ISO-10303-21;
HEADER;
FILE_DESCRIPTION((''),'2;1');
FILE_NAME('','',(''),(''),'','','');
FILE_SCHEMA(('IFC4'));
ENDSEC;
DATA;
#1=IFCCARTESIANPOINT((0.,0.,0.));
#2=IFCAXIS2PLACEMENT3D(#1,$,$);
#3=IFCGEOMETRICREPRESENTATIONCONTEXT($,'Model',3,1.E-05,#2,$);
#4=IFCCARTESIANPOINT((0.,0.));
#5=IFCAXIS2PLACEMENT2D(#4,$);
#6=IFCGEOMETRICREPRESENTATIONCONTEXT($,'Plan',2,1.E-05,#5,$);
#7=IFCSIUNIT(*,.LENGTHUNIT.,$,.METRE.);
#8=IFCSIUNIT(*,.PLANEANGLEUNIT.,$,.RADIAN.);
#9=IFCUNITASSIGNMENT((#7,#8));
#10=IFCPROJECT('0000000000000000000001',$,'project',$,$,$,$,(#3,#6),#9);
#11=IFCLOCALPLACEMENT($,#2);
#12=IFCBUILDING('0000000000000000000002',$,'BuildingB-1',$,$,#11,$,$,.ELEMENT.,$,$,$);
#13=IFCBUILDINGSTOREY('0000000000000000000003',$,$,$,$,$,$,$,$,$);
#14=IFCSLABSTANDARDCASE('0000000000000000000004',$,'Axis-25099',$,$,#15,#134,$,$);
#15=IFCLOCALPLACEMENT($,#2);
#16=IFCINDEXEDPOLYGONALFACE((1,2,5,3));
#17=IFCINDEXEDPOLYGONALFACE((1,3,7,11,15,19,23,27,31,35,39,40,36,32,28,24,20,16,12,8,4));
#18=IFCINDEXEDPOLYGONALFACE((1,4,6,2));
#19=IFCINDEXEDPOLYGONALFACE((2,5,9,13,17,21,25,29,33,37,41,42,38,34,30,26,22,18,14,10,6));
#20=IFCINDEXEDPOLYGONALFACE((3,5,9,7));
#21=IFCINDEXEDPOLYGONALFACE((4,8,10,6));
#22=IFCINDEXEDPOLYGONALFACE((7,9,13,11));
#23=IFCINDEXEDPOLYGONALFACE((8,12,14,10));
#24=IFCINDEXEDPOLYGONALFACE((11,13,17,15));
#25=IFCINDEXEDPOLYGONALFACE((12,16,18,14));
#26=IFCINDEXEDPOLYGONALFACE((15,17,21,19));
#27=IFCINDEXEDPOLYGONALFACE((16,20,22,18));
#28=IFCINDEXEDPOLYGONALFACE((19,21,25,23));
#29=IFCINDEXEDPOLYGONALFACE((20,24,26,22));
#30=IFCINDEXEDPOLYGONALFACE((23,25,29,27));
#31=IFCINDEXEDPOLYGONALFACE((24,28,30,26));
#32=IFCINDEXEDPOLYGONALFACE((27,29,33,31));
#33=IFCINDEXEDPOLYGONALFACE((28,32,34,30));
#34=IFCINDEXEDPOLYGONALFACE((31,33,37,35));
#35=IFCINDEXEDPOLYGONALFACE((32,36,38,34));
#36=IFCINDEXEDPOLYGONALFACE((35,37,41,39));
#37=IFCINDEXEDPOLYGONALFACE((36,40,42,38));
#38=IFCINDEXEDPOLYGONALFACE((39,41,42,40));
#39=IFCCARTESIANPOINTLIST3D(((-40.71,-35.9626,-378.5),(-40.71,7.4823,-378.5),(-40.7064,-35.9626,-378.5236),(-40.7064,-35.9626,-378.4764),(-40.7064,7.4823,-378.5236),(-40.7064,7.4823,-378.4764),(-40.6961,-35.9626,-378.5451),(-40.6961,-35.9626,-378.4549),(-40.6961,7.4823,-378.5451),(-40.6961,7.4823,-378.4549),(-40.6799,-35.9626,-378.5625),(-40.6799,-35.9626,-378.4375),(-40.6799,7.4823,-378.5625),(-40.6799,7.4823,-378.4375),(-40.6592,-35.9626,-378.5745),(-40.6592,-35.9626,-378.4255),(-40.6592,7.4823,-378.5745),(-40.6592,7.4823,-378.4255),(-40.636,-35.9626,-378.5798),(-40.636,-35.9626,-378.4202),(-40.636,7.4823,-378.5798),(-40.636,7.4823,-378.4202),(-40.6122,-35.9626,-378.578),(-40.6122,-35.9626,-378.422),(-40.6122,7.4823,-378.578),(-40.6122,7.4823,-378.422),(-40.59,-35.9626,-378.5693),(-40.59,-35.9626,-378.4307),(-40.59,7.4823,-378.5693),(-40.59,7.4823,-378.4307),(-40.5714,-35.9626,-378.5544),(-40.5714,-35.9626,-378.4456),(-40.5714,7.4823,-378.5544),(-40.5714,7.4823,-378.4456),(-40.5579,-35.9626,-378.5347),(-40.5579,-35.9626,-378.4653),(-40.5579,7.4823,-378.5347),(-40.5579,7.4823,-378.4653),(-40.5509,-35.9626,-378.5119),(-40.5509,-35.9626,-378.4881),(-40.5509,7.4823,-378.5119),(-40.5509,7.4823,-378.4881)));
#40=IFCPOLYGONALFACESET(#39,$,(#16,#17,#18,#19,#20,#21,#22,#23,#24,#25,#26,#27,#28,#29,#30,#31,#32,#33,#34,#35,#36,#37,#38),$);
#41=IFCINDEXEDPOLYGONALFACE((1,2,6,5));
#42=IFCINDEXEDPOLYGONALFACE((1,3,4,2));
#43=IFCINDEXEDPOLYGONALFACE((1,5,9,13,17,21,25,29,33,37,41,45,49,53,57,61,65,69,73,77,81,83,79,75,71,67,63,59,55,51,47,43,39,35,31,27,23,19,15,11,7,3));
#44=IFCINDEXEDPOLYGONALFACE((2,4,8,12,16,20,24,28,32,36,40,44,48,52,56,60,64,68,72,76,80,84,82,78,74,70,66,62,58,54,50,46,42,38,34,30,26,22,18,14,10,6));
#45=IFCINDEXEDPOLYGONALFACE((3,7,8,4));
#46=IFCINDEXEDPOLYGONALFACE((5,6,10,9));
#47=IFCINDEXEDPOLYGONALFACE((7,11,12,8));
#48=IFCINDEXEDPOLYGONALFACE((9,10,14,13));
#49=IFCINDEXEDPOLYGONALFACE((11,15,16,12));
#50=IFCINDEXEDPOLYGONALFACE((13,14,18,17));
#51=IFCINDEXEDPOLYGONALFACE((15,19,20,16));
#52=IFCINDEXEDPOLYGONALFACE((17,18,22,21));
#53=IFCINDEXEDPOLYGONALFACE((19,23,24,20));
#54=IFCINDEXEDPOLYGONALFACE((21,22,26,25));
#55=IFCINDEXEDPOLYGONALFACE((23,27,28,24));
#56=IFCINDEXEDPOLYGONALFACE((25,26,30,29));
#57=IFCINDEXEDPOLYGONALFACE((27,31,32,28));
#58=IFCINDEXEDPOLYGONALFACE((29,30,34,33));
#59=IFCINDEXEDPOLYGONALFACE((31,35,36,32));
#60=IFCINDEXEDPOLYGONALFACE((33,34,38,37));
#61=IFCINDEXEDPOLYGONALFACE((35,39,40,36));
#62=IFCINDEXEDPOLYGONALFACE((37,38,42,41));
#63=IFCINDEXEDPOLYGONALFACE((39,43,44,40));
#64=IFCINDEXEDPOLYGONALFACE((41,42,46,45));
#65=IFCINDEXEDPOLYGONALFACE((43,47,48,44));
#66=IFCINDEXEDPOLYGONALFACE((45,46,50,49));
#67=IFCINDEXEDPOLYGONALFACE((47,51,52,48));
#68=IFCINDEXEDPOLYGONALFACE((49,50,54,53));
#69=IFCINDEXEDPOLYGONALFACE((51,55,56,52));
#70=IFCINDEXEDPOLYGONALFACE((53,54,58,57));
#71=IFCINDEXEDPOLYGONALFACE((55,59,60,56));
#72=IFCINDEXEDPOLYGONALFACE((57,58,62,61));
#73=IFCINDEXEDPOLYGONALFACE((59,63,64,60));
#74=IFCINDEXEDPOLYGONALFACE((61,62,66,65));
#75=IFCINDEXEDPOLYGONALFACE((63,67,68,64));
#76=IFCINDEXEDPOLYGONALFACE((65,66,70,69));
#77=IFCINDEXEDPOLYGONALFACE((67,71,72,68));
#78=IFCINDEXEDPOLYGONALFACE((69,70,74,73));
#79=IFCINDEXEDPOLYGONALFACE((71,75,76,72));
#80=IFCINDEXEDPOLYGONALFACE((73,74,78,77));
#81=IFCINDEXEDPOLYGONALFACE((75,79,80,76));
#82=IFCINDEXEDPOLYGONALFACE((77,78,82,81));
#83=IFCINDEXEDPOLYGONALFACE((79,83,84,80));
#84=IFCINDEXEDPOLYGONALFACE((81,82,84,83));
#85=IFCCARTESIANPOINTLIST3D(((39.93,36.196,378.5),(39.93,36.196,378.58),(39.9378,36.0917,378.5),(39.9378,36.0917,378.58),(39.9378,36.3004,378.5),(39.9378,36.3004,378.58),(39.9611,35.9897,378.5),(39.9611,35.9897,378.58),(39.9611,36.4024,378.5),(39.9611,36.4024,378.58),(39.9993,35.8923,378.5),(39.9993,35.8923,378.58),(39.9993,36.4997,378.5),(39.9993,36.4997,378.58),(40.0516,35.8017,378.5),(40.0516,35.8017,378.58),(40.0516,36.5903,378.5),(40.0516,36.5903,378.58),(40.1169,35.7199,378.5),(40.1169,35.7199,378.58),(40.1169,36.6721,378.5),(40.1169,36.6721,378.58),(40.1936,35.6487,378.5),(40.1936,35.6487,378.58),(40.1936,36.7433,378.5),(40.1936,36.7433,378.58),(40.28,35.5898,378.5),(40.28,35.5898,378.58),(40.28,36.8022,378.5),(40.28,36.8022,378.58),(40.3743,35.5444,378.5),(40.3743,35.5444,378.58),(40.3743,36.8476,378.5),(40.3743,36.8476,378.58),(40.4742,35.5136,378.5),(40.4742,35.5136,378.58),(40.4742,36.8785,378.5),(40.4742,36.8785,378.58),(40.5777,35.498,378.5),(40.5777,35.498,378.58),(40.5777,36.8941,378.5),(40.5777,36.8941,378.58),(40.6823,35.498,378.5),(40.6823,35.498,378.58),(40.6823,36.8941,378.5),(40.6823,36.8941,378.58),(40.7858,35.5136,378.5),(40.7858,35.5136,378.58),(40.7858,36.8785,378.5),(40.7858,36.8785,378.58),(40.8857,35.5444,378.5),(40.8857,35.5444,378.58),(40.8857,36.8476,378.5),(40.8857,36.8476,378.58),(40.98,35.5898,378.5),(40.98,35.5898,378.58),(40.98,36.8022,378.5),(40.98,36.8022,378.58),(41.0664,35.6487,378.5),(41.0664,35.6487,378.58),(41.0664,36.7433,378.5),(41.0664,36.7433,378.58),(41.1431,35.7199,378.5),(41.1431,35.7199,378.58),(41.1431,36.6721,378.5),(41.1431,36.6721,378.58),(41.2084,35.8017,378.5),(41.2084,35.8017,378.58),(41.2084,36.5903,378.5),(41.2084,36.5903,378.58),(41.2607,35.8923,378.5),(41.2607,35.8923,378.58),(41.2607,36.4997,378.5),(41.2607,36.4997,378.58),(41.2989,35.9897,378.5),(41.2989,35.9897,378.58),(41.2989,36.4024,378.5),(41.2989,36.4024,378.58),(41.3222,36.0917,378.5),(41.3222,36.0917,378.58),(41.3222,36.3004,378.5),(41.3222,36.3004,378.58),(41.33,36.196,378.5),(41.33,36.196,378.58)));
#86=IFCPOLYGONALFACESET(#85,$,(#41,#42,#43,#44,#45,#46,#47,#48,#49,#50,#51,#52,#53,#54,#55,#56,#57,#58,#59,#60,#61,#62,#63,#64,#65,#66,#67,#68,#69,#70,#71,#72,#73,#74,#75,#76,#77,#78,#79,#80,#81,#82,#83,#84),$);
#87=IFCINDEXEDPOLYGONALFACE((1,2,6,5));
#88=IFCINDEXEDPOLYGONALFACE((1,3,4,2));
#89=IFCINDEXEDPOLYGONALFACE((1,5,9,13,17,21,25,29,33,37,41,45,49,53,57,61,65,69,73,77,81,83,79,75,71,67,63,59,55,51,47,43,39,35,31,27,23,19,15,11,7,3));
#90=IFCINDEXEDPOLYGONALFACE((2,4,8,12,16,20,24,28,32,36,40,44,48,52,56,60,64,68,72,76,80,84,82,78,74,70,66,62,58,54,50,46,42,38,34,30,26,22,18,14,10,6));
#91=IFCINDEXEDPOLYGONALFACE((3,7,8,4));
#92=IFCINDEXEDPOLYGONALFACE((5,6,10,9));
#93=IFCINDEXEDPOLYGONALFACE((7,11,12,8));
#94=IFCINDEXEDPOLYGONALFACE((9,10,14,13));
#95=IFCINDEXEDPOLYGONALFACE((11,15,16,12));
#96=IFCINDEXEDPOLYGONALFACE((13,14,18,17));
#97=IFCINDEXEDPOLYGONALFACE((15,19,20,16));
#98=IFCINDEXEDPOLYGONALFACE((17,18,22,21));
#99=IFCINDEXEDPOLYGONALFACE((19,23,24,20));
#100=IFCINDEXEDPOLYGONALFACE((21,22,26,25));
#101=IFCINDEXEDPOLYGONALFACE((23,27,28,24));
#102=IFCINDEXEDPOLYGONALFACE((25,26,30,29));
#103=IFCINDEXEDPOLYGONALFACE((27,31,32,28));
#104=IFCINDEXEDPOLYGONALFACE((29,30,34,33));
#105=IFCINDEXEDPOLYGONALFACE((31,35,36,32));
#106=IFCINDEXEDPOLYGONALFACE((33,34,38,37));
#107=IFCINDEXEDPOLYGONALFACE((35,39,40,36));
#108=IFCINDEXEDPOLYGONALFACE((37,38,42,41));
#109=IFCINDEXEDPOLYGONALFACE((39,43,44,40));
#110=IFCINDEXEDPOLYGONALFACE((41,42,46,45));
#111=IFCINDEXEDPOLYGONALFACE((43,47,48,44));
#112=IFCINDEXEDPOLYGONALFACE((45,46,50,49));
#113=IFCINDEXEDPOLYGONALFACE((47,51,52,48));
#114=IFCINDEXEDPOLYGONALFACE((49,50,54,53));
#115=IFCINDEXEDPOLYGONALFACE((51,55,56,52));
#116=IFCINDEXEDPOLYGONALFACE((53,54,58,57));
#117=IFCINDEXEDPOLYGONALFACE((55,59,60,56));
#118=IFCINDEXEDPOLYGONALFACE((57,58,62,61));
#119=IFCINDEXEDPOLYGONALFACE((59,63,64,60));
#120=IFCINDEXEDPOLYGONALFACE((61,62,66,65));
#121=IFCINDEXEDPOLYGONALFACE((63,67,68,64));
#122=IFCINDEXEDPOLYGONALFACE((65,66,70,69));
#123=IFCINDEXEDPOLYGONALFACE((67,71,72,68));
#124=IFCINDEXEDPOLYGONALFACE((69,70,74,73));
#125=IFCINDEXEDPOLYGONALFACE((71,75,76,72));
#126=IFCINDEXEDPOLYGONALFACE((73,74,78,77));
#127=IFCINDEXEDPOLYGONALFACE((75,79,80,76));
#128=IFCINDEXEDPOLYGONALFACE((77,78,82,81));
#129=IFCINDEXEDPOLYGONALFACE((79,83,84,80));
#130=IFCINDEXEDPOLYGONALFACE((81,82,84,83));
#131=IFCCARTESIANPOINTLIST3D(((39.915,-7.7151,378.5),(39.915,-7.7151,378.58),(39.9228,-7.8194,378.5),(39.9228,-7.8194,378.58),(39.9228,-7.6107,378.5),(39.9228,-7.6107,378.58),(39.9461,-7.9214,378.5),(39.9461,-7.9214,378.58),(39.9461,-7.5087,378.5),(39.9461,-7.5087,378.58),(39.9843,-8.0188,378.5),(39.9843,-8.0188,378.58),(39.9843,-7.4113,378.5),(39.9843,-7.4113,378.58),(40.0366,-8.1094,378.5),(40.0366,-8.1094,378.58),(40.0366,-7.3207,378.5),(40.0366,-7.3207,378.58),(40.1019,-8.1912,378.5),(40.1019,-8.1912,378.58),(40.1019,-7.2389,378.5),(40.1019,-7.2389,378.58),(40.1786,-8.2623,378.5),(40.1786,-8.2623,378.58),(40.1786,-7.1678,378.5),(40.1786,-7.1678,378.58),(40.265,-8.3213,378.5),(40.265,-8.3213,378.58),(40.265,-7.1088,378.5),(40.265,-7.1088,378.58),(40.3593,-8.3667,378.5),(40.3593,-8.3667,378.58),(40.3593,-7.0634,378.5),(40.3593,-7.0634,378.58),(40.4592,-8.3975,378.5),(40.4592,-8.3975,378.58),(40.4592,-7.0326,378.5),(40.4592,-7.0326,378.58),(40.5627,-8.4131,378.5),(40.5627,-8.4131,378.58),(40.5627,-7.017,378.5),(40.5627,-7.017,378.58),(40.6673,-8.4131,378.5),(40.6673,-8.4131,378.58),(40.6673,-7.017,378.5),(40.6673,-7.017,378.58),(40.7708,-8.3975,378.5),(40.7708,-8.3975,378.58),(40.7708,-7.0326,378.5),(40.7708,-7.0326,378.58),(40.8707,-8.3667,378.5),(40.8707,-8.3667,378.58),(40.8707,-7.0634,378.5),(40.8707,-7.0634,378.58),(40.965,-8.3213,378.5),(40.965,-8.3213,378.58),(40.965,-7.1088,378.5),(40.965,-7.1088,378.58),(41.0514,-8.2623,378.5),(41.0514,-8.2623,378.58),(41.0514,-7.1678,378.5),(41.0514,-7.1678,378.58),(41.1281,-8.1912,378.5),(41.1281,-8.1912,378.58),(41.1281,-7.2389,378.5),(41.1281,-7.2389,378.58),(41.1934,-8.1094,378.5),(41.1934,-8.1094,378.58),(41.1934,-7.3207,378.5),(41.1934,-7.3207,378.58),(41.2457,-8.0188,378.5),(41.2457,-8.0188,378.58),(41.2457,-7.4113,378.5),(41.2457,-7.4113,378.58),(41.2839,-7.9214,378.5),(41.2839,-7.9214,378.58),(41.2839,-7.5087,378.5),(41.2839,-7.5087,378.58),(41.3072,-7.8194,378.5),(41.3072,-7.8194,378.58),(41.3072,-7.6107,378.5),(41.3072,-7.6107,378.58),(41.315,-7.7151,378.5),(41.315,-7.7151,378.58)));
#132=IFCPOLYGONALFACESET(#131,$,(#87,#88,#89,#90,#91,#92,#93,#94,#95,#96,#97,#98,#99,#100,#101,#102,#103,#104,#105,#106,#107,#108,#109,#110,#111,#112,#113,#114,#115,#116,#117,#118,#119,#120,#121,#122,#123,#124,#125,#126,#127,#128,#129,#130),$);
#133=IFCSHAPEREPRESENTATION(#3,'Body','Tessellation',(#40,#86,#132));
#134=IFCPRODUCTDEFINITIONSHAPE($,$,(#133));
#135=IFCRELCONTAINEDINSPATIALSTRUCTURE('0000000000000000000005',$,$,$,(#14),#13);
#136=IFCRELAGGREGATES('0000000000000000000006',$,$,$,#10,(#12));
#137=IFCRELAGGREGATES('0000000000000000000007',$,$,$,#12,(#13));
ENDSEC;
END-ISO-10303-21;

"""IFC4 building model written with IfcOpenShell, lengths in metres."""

from ifc_helpers import new_model, entity, si_unit, frame, origin, origin_2d, place, context, project, spatial, circle, extrude, element, save


model = new_model("IFC4")

# Units and contexts
model_context = context("Model", 3, precision=1e-05, world=origin())
plan_context = context("Plan", 2, precision=1e-05, world=origin_2d())
ifc_project = project(units=[si_unit("LENGTHUNIT", "METRE"), si_unit("PLANEANGLEUNIT", "RADIAN")], contexts=[model_context, plan_context])

# Building, storey
building_placement = place(None, origin())
building = spatial("IfcBuilding", under=ifc_project, at=building_placement, Name="BuildingB-1", CompositionType="ELEMENT")
storey = spatial("IfcBuildingStorey", under=building)

# Slab
element("IfcSlabStandardCase", 1, inside=storey, Name="Axis-25099", context=model_context, shape_type="AdvancedSweptSolid", body=[
    entity("IfcSurfaceCurveSweptAreaSolid", entity("IfcCircleProfileDef", "AREA", None, None, 0.08), None, entity("IfcPolyline", [entity("IfcCartesianPoint", [40.63, 35.9626, 378.5]), entity("IfcCartesianPoint", [40.63, -7.4823, 378.5])]), None, None, entity("IfcPlane", entity("IfcAxis2Placement3D", entity("IfcCartesianPoint", [40.63, 35.9626, 378.5]), entity("IfcDirection", [0.0, 0.0, 1.0]), entity("IfcDirection", [1.0, 0.0, 0.0])))),
    extrude(circle(Radius=0.7), frame((40.63, 36.196, 378.5)), (0.0, 0.0, 1.0), 0.08),
    extrude(circle(Radius=0.7), frame((40.615, -7.7151, 378.5)), (0.0, 0.0, 1.0), 0.08),
])

save(model, "model.ifc")
